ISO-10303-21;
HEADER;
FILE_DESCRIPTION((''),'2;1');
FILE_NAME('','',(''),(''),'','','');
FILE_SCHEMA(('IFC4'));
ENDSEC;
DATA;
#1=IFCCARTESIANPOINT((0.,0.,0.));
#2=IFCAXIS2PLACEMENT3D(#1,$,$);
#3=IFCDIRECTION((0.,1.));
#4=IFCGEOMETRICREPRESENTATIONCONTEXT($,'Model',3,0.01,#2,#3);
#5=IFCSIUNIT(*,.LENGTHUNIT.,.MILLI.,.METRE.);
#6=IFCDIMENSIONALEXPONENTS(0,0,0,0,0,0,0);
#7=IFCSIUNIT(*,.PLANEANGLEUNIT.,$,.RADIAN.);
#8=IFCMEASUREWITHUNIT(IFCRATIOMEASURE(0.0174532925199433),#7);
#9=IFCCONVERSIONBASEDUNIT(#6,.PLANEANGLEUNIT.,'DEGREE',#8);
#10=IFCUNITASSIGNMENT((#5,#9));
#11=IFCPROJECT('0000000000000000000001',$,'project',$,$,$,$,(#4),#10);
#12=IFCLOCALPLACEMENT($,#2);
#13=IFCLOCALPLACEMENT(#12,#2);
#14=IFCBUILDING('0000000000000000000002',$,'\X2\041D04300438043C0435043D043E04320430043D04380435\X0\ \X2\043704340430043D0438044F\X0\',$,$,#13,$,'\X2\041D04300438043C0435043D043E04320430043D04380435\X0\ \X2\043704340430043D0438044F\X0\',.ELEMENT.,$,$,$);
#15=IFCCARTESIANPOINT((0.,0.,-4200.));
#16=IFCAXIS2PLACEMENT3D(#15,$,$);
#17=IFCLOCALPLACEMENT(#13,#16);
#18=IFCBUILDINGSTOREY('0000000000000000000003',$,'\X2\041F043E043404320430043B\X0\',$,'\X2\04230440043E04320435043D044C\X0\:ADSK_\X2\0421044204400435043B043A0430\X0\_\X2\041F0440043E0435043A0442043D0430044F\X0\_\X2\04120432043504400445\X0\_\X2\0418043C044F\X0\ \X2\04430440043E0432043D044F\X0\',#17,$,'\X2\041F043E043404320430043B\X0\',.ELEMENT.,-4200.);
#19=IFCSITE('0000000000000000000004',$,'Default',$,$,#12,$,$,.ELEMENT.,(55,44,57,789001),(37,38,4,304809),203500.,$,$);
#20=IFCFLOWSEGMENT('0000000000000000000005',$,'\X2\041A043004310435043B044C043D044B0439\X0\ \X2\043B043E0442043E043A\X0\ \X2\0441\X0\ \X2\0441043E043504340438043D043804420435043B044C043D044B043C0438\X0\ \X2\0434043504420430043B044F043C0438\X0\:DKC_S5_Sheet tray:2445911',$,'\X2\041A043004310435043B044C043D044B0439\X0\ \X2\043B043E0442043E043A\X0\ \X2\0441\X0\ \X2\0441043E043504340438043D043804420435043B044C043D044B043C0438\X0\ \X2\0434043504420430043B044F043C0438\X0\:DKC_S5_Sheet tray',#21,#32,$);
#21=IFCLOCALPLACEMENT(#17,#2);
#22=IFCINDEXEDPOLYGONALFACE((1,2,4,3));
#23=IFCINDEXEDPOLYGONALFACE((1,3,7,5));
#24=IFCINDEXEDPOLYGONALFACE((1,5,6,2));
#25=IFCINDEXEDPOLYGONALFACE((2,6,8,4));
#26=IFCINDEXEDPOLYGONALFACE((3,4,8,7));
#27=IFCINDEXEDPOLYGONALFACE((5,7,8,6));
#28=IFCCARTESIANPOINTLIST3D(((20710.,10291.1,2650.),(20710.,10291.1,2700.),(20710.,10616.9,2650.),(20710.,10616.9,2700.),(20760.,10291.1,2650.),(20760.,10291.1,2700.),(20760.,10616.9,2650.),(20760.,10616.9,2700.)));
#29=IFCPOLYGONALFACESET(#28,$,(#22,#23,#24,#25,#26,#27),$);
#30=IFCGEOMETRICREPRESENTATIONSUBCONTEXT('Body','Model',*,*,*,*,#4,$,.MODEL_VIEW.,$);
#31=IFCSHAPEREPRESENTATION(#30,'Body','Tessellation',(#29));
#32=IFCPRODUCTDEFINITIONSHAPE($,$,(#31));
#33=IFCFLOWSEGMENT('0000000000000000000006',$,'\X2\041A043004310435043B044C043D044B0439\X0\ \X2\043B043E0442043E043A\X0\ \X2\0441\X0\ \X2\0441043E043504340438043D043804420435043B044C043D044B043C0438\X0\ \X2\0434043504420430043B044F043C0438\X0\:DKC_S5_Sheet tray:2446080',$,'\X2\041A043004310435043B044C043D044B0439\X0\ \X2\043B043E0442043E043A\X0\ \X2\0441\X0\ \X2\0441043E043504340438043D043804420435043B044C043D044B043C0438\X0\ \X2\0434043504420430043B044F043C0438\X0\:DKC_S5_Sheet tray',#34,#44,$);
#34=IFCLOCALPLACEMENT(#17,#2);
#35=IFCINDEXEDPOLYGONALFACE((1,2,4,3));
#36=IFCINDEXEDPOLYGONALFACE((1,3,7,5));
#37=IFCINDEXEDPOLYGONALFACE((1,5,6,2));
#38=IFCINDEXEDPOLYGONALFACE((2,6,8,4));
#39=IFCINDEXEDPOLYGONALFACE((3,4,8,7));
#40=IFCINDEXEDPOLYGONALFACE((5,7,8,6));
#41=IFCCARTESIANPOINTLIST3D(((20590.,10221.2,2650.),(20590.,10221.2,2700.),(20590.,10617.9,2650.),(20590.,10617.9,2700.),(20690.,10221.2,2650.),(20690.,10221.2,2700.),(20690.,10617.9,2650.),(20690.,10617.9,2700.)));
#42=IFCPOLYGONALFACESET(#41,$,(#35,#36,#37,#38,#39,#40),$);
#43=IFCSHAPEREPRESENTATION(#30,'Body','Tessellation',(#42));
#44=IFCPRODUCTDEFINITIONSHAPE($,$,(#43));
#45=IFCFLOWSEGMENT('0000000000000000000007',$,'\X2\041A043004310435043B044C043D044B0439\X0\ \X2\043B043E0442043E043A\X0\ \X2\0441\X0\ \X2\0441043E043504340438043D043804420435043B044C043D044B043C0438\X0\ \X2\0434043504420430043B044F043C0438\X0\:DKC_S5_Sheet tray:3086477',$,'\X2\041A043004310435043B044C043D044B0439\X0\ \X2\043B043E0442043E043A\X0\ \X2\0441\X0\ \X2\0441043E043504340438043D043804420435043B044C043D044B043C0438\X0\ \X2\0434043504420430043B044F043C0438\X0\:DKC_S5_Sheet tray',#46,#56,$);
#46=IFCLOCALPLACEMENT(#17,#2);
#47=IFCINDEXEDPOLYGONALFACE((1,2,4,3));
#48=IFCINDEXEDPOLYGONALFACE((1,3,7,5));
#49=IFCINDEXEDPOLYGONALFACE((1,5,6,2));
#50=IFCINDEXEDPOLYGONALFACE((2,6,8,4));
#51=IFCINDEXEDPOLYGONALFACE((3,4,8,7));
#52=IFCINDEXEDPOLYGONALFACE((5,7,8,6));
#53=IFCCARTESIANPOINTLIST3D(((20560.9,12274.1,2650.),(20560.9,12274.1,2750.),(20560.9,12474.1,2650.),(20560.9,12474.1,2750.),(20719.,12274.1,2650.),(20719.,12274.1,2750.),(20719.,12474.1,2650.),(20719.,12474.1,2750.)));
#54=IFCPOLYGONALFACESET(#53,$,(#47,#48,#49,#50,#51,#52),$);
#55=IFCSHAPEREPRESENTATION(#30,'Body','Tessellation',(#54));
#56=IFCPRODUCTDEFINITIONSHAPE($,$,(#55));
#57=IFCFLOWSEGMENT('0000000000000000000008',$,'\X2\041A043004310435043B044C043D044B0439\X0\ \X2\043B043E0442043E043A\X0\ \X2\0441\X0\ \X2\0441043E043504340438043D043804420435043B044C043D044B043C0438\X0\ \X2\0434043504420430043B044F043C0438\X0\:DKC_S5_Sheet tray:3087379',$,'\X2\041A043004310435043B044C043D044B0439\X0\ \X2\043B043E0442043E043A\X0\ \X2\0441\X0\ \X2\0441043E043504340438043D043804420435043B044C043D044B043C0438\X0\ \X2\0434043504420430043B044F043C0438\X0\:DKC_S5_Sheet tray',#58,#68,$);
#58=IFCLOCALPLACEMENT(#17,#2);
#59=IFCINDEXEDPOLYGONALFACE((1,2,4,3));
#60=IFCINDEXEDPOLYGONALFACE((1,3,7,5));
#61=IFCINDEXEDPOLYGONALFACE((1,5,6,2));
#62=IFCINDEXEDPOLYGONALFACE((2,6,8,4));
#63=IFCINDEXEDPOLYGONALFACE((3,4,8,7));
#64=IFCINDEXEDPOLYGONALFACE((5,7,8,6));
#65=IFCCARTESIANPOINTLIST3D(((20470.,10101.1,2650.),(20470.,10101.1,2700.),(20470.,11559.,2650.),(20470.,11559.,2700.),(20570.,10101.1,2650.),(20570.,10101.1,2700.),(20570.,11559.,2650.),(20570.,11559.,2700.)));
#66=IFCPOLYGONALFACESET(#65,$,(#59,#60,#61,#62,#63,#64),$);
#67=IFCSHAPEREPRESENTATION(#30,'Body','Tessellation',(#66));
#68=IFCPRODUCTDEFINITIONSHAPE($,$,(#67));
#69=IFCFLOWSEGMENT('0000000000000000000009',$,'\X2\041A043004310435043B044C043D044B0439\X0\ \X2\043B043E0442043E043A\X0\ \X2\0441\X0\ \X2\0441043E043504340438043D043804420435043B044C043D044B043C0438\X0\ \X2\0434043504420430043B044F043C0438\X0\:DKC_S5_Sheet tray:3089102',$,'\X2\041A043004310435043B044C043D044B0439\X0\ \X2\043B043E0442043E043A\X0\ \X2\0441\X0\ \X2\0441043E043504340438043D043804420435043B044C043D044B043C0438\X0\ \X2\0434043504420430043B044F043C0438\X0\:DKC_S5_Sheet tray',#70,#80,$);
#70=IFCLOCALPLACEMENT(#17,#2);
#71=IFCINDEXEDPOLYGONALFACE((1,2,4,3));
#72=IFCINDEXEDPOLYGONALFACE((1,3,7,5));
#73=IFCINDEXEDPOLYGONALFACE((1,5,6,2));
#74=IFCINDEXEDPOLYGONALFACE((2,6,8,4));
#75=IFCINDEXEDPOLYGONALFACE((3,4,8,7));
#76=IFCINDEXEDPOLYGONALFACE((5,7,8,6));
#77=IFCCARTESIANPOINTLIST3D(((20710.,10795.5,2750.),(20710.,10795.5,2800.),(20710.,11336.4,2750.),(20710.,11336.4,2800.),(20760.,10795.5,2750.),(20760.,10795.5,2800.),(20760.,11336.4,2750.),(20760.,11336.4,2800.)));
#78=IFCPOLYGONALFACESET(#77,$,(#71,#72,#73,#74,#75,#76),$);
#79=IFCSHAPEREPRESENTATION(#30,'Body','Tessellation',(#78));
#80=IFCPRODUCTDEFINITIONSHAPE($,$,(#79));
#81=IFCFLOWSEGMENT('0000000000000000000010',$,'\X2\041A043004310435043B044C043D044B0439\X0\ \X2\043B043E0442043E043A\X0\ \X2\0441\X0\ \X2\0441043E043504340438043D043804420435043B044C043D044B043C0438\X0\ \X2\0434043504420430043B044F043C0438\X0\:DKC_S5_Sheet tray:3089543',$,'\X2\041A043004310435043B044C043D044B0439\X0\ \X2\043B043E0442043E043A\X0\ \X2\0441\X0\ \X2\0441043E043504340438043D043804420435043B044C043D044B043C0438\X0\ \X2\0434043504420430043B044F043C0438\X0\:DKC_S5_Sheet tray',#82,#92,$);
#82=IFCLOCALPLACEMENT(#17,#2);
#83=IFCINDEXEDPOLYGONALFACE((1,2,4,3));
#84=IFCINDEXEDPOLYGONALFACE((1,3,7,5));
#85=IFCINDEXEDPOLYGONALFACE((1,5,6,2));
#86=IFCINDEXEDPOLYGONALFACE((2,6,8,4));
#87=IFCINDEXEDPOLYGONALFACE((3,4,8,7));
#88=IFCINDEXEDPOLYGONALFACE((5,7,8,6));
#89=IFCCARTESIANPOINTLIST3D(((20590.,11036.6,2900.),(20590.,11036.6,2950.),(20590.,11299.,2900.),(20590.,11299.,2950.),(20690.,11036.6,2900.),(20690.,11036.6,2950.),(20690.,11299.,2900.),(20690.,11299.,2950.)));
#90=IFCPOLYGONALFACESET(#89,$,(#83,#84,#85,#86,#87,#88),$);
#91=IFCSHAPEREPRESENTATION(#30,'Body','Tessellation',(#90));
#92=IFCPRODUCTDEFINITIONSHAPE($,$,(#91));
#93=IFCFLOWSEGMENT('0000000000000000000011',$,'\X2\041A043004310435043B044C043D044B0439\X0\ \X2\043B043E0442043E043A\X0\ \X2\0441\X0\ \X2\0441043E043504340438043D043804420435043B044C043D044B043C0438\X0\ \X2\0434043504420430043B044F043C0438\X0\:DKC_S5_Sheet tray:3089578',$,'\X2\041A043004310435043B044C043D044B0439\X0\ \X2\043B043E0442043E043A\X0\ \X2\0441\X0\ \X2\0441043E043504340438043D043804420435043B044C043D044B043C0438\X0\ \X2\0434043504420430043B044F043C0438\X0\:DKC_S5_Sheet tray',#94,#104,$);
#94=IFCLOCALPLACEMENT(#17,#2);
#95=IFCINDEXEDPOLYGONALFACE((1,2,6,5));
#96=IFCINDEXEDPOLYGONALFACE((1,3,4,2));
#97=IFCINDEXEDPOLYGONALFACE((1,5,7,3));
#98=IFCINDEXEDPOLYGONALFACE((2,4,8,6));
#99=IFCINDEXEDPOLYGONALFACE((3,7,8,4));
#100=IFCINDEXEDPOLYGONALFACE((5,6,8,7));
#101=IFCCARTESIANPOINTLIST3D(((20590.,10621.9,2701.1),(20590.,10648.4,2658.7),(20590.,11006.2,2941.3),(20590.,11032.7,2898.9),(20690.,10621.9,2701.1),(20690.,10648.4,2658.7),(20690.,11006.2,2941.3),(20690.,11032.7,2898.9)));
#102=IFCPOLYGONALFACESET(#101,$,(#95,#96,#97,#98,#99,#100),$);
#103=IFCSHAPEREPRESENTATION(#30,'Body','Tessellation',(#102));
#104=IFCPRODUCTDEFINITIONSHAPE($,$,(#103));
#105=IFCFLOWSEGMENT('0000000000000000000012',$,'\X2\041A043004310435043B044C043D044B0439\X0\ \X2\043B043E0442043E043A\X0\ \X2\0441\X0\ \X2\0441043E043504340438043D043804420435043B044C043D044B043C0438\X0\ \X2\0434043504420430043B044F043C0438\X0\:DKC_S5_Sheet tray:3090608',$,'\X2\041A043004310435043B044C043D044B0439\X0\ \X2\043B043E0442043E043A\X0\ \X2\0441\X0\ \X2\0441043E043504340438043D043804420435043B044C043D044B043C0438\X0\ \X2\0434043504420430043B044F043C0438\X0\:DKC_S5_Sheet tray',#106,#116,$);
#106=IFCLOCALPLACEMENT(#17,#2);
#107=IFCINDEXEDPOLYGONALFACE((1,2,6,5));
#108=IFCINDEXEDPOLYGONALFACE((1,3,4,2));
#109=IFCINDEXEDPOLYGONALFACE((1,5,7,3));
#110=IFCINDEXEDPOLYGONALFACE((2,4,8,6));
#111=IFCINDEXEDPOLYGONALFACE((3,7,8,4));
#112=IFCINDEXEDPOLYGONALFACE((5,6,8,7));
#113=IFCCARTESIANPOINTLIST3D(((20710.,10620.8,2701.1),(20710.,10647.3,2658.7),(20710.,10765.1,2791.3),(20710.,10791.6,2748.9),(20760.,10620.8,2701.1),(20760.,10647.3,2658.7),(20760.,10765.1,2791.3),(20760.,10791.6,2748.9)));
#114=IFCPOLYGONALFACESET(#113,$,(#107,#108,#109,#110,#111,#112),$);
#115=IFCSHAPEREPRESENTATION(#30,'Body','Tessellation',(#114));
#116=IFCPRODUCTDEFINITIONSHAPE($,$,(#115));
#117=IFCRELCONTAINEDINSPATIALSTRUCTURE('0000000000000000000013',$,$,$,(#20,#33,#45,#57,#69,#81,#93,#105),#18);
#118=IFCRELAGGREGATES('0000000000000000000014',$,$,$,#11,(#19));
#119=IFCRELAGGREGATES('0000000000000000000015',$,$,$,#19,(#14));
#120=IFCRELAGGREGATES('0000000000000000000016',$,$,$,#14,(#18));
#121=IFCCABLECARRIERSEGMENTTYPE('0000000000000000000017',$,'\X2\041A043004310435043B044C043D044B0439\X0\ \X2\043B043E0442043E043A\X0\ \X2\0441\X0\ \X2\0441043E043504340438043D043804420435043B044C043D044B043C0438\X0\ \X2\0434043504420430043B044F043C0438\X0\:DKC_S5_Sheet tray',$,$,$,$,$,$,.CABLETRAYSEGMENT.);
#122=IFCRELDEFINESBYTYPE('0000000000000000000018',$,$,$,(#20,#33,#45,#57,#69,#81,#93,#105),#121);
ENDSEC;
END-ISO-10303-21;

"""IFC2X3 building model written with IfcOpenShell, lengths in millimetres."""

from ifc_helpers import new_model, entity, si_unit, converted_unit, direction, frame, frame_2d, origin, origin_2d_with_axis, place, context, subcontext, project, spatial, rectangle, extrude, type_object, element, save


model = new_model("IFC2X3")

# Units and contexts
model_context = context("Model", 3, precision=0.01, world=origin(), true_north=direction((0.0, 1.0)))
body_context = subcontext(model_context, "Body", "Model", "MODEL_VIEW")
ifc_project = project(units=[si_unit("LENGTHUNIT", "METRE", prefix="MILLI"), converted_unit("PLANEANGLEUNIT", "DEGREE", entity("IfcRatioMeasure", 0.0174532925199433), si_unit("PLANEANGLEUNIT", "RADIAN"), dimensions=[0, 0, 0, 0, 0, 0, 0])], contexts=[model_context])

# Site, building, storey
site_placement = place(None, origin())
site = spatial("IfcSite", under=ifc_project, at=site_placement, Name="Default", CompositionType="ELEMENT", RefLatitude=(55, 44, 57, 789001), RefLongitude=(37, 38, 4, 304809), RefElevation=203500.0)
building_placement = place(site_placement, origin())
building = spatial("IfcBuilding", under=site, at=building_placement, Name="Наименование здания", LongName="Наименование здания", CompositionType="ELEMENT")
storey_placement = place(building_placement, frame((0.0, 0.0, -4200.0)))
storey = spatial("IfcBuildingStorey", under=building, at=storey_placement, Name="Подвал", ObjectType="Уровень:ADSK_Стрелка_Проектная_Вверх_Имя уровня", LongName="Подвал", CompositionType="ELEMENT", Elevation=-4200.0)

# Flow segments
cable_carrier_segment_type = type_object("IfcCableCarrierSegmentType", Name="Кабельный лоток с соединительными деталями:DKC_S5_Sheet tray", PredefinedType="CABLETRAYSEGMENT")
flow_segment_1_placement = place(storey_placement, frame((20710.0, 10291.1, 2650.0)))
element("IfcFlowSegment", 1, at=flow_segment_1_placement, inside=storey, type_object=cable_carrier_segment_type, Name="Кабельный лоток с соединительными деталями:DKC_S5_Sheet tray:2445911", ObjectType="Кабельный лоток с соединительными деталями:DKC_S5_Sheet tray", context=body_context, shape_type="SweptSolid", body=[
    extrude(rectangle(XDim=325.7, YDim=50.0, at=origin_2d_with_axis()), frame((25.0, 162.8, 0.0), z_axis=(0.0, 0.0, 1.0), x_axis=(0.0, 1.0, 0.0)), (0.0, 0.0, 1.0), 50.0),
])
flow_segment_2_placement = place(storey_placement, frame((20590.0, 10221.1, 2650.0)))
element("IfcFlowSegment", 2, at=flow_segment_2_placement, inside=storey, type_object=cable_carrier_segment_type, Name="Кабельный лоток с соединительными деталями:DKC_S5_Sheet tray:2446080", ObjectType="Кабельный лоток с соединительными деталями:DKC_S5_Sheet tray", context=body_context, shape_type="SweptSolid", body=[
    extrude(rectangle(XDim=396.8, YDim=100.0, at=origin_2d_with_axis()), frame((50.0, 198.4, 0.0), z_axis=(0.0, 0.0, 1.0), x_axis=(0.0, 1.0, 0.0)), (0.0, 0.0, 1.0), 50.0),
])
flow_segment_3_placement = place(storey_placement, frame((20560.9, 12274.1, 2650.0)))
element("IfcFlowSegment", 3, at=flow_segment_3_placement, inside=storey, type_object=cable_carrier_segment_type, Name="Кабельный лоток с соединительными деталями:DKC_S5_Sheet tray:3086477", ObjectType="Кабельный лоток с соединительными деталями:DKC_S5_Sheet tray", context=body_context, shape_type="SweptSolid", body=[
    extrude(rectangle(XDim=158.1, YDim=200.0, at=origin_2d_with_axis()), frame((79.0, 100.0, 0.0), z_axis=(0.0, 0.0, 1.0), x_axis=(-1.0, 0.0, 0.0)), (0.0, 0.0, 1.0), 100.0),
])
flow_segment_4_placement = place(storey_placement, frame((20470.0, 10101.1, 2650.0)))
element("IfcFlowSegment", 4, at=flow_segment_4_placement, inside=storey, type_object=cable_carrier_segment_type, Name="Кабельный лоток с соединительными деталями:DKC_S5_Sheet tray:3087379", ObjectType="Кабельный лоток с соединительными деталями:DKC_S5_Sheet tray", context=body_context, shape_type="SweptSolid", body=[
    extrude(rectangle(XDim=1457.8, YDim=100.0, at=origin_2d_with_axis()), frame((50.0, 728.9, 0.0), z_axis=(0.0, 0.0, 1.0), x_axis=(0.0, 1.0, 0.0)), (0.0, 0.0, 1.0), 50.0),
])
flow_segment_5_placement = place(storey_placement, frame((20710.0, 10795.5, 2750.0)))
element("IfcFlowSegment", 5, at=flow_segment_5_placement, inside=storey, type_object=cable_carrier_segment_type, Name="Кабельный лоток с соединительными деталями:DKC_S5_Sheet tray:3089102", ObjectType="Кабельный лоток с соединительными деталями:DKC_S5_Sheet tray", context=body_context, shape_type="SweptSolid", body=[
    extrude(rectangle(XDim=540.9, YDim=50.0, at=origin_2d_with_axis()), frame((25.0, 270.5, 0.0), z_axis=(0.0, 0.0, 1.0), x_axis=(0.0, -1.0, 0.0)), (0.0, 0.0, 1.0), 50.0),
])
flow_segment_6_placement = place(storey_placement, frame((20590.0, 11036.6, 2900.0)))
element("IfcFlowSegment", 6, at=flow_segment_6_placement, inside=storey, type_object=cable_carrier_segment_type, Name="Кабельный лоток с соединительными деталями:DKC_S5_Sheet tray:3089543", ObjectType="Кабельный лоток с соединительными деталями:DKC_S5_Sheet tray", context=body_context, shape_type="SweptSolid", body=[
    extrude(rectangle(XDim=262.3, YDim=100.0, at=origin_2d_with_axis()), frame((50.0, 131.2, 0.0), z_axis=(0.0, 0.0, 1.0), x_axis=(0.0, -1.0, 0.0)), (0.0, 0.0, 1.0), 50.0),
])
flow_segment_7_placement = place(storey_placement, frame((20590.0, 10621.9, 2658.7)))
element("IfcFlowSegment", 7, at=flow_segment_7_placement, inside=storey, type_object=cable_carrier_segment_type, Name="Кабельный лоток с соединительными деталями:DKC_S5_Sheet tray:3089578", ObjectType="Кабельный лоток с соединительными деталями:DKC_S5_Sheet tray", context=body_context, shape_type="SweptSolid", body=[
    extrude(rectangle(XDim=50.0, YDim=453.1, at=frame_2d((0.0, 0.0), x_axis=(0.0, 1.0))), frame((0.0, 205.4, 141.3), z_axis=(1.0, 0.0, 0.0), x_axis=(0.0, 0.848048, 0.529919)), (0.0, 0.0, 1.0), 100.0),
])
flow_segment_8_placement = place(storey_placement, frame((20710.0, 10620.8, 2658.7)))
element("IfcFlowSegment", 8, at=flow_segment_8_placement, inside=storey, type_object=cable_carrier_segment_type, Name="Кабельный лоток с соединительными деталями:DKC_S5_Sheet tray:3090608", ObjectType="Кабельный лоток с соединительными деталями:DKC_S5_Sheet tray", context=body_context, shape_type="SweptSolid", body=[
    extrude(rectangle(XDim=50.0, YDim=50.0, at=frame_2d((0.0, 0.0), x_axis=(0.0, 1.0))), frame((25.0, 13.2, 21.2), z_axis=(0.0, 0.848048, 0.529919), x_axis=(-1.0, 0.0, 0.0)), (0.0, 0.0, 1.0), 170.1),
])

save(model, "model.ifc")
